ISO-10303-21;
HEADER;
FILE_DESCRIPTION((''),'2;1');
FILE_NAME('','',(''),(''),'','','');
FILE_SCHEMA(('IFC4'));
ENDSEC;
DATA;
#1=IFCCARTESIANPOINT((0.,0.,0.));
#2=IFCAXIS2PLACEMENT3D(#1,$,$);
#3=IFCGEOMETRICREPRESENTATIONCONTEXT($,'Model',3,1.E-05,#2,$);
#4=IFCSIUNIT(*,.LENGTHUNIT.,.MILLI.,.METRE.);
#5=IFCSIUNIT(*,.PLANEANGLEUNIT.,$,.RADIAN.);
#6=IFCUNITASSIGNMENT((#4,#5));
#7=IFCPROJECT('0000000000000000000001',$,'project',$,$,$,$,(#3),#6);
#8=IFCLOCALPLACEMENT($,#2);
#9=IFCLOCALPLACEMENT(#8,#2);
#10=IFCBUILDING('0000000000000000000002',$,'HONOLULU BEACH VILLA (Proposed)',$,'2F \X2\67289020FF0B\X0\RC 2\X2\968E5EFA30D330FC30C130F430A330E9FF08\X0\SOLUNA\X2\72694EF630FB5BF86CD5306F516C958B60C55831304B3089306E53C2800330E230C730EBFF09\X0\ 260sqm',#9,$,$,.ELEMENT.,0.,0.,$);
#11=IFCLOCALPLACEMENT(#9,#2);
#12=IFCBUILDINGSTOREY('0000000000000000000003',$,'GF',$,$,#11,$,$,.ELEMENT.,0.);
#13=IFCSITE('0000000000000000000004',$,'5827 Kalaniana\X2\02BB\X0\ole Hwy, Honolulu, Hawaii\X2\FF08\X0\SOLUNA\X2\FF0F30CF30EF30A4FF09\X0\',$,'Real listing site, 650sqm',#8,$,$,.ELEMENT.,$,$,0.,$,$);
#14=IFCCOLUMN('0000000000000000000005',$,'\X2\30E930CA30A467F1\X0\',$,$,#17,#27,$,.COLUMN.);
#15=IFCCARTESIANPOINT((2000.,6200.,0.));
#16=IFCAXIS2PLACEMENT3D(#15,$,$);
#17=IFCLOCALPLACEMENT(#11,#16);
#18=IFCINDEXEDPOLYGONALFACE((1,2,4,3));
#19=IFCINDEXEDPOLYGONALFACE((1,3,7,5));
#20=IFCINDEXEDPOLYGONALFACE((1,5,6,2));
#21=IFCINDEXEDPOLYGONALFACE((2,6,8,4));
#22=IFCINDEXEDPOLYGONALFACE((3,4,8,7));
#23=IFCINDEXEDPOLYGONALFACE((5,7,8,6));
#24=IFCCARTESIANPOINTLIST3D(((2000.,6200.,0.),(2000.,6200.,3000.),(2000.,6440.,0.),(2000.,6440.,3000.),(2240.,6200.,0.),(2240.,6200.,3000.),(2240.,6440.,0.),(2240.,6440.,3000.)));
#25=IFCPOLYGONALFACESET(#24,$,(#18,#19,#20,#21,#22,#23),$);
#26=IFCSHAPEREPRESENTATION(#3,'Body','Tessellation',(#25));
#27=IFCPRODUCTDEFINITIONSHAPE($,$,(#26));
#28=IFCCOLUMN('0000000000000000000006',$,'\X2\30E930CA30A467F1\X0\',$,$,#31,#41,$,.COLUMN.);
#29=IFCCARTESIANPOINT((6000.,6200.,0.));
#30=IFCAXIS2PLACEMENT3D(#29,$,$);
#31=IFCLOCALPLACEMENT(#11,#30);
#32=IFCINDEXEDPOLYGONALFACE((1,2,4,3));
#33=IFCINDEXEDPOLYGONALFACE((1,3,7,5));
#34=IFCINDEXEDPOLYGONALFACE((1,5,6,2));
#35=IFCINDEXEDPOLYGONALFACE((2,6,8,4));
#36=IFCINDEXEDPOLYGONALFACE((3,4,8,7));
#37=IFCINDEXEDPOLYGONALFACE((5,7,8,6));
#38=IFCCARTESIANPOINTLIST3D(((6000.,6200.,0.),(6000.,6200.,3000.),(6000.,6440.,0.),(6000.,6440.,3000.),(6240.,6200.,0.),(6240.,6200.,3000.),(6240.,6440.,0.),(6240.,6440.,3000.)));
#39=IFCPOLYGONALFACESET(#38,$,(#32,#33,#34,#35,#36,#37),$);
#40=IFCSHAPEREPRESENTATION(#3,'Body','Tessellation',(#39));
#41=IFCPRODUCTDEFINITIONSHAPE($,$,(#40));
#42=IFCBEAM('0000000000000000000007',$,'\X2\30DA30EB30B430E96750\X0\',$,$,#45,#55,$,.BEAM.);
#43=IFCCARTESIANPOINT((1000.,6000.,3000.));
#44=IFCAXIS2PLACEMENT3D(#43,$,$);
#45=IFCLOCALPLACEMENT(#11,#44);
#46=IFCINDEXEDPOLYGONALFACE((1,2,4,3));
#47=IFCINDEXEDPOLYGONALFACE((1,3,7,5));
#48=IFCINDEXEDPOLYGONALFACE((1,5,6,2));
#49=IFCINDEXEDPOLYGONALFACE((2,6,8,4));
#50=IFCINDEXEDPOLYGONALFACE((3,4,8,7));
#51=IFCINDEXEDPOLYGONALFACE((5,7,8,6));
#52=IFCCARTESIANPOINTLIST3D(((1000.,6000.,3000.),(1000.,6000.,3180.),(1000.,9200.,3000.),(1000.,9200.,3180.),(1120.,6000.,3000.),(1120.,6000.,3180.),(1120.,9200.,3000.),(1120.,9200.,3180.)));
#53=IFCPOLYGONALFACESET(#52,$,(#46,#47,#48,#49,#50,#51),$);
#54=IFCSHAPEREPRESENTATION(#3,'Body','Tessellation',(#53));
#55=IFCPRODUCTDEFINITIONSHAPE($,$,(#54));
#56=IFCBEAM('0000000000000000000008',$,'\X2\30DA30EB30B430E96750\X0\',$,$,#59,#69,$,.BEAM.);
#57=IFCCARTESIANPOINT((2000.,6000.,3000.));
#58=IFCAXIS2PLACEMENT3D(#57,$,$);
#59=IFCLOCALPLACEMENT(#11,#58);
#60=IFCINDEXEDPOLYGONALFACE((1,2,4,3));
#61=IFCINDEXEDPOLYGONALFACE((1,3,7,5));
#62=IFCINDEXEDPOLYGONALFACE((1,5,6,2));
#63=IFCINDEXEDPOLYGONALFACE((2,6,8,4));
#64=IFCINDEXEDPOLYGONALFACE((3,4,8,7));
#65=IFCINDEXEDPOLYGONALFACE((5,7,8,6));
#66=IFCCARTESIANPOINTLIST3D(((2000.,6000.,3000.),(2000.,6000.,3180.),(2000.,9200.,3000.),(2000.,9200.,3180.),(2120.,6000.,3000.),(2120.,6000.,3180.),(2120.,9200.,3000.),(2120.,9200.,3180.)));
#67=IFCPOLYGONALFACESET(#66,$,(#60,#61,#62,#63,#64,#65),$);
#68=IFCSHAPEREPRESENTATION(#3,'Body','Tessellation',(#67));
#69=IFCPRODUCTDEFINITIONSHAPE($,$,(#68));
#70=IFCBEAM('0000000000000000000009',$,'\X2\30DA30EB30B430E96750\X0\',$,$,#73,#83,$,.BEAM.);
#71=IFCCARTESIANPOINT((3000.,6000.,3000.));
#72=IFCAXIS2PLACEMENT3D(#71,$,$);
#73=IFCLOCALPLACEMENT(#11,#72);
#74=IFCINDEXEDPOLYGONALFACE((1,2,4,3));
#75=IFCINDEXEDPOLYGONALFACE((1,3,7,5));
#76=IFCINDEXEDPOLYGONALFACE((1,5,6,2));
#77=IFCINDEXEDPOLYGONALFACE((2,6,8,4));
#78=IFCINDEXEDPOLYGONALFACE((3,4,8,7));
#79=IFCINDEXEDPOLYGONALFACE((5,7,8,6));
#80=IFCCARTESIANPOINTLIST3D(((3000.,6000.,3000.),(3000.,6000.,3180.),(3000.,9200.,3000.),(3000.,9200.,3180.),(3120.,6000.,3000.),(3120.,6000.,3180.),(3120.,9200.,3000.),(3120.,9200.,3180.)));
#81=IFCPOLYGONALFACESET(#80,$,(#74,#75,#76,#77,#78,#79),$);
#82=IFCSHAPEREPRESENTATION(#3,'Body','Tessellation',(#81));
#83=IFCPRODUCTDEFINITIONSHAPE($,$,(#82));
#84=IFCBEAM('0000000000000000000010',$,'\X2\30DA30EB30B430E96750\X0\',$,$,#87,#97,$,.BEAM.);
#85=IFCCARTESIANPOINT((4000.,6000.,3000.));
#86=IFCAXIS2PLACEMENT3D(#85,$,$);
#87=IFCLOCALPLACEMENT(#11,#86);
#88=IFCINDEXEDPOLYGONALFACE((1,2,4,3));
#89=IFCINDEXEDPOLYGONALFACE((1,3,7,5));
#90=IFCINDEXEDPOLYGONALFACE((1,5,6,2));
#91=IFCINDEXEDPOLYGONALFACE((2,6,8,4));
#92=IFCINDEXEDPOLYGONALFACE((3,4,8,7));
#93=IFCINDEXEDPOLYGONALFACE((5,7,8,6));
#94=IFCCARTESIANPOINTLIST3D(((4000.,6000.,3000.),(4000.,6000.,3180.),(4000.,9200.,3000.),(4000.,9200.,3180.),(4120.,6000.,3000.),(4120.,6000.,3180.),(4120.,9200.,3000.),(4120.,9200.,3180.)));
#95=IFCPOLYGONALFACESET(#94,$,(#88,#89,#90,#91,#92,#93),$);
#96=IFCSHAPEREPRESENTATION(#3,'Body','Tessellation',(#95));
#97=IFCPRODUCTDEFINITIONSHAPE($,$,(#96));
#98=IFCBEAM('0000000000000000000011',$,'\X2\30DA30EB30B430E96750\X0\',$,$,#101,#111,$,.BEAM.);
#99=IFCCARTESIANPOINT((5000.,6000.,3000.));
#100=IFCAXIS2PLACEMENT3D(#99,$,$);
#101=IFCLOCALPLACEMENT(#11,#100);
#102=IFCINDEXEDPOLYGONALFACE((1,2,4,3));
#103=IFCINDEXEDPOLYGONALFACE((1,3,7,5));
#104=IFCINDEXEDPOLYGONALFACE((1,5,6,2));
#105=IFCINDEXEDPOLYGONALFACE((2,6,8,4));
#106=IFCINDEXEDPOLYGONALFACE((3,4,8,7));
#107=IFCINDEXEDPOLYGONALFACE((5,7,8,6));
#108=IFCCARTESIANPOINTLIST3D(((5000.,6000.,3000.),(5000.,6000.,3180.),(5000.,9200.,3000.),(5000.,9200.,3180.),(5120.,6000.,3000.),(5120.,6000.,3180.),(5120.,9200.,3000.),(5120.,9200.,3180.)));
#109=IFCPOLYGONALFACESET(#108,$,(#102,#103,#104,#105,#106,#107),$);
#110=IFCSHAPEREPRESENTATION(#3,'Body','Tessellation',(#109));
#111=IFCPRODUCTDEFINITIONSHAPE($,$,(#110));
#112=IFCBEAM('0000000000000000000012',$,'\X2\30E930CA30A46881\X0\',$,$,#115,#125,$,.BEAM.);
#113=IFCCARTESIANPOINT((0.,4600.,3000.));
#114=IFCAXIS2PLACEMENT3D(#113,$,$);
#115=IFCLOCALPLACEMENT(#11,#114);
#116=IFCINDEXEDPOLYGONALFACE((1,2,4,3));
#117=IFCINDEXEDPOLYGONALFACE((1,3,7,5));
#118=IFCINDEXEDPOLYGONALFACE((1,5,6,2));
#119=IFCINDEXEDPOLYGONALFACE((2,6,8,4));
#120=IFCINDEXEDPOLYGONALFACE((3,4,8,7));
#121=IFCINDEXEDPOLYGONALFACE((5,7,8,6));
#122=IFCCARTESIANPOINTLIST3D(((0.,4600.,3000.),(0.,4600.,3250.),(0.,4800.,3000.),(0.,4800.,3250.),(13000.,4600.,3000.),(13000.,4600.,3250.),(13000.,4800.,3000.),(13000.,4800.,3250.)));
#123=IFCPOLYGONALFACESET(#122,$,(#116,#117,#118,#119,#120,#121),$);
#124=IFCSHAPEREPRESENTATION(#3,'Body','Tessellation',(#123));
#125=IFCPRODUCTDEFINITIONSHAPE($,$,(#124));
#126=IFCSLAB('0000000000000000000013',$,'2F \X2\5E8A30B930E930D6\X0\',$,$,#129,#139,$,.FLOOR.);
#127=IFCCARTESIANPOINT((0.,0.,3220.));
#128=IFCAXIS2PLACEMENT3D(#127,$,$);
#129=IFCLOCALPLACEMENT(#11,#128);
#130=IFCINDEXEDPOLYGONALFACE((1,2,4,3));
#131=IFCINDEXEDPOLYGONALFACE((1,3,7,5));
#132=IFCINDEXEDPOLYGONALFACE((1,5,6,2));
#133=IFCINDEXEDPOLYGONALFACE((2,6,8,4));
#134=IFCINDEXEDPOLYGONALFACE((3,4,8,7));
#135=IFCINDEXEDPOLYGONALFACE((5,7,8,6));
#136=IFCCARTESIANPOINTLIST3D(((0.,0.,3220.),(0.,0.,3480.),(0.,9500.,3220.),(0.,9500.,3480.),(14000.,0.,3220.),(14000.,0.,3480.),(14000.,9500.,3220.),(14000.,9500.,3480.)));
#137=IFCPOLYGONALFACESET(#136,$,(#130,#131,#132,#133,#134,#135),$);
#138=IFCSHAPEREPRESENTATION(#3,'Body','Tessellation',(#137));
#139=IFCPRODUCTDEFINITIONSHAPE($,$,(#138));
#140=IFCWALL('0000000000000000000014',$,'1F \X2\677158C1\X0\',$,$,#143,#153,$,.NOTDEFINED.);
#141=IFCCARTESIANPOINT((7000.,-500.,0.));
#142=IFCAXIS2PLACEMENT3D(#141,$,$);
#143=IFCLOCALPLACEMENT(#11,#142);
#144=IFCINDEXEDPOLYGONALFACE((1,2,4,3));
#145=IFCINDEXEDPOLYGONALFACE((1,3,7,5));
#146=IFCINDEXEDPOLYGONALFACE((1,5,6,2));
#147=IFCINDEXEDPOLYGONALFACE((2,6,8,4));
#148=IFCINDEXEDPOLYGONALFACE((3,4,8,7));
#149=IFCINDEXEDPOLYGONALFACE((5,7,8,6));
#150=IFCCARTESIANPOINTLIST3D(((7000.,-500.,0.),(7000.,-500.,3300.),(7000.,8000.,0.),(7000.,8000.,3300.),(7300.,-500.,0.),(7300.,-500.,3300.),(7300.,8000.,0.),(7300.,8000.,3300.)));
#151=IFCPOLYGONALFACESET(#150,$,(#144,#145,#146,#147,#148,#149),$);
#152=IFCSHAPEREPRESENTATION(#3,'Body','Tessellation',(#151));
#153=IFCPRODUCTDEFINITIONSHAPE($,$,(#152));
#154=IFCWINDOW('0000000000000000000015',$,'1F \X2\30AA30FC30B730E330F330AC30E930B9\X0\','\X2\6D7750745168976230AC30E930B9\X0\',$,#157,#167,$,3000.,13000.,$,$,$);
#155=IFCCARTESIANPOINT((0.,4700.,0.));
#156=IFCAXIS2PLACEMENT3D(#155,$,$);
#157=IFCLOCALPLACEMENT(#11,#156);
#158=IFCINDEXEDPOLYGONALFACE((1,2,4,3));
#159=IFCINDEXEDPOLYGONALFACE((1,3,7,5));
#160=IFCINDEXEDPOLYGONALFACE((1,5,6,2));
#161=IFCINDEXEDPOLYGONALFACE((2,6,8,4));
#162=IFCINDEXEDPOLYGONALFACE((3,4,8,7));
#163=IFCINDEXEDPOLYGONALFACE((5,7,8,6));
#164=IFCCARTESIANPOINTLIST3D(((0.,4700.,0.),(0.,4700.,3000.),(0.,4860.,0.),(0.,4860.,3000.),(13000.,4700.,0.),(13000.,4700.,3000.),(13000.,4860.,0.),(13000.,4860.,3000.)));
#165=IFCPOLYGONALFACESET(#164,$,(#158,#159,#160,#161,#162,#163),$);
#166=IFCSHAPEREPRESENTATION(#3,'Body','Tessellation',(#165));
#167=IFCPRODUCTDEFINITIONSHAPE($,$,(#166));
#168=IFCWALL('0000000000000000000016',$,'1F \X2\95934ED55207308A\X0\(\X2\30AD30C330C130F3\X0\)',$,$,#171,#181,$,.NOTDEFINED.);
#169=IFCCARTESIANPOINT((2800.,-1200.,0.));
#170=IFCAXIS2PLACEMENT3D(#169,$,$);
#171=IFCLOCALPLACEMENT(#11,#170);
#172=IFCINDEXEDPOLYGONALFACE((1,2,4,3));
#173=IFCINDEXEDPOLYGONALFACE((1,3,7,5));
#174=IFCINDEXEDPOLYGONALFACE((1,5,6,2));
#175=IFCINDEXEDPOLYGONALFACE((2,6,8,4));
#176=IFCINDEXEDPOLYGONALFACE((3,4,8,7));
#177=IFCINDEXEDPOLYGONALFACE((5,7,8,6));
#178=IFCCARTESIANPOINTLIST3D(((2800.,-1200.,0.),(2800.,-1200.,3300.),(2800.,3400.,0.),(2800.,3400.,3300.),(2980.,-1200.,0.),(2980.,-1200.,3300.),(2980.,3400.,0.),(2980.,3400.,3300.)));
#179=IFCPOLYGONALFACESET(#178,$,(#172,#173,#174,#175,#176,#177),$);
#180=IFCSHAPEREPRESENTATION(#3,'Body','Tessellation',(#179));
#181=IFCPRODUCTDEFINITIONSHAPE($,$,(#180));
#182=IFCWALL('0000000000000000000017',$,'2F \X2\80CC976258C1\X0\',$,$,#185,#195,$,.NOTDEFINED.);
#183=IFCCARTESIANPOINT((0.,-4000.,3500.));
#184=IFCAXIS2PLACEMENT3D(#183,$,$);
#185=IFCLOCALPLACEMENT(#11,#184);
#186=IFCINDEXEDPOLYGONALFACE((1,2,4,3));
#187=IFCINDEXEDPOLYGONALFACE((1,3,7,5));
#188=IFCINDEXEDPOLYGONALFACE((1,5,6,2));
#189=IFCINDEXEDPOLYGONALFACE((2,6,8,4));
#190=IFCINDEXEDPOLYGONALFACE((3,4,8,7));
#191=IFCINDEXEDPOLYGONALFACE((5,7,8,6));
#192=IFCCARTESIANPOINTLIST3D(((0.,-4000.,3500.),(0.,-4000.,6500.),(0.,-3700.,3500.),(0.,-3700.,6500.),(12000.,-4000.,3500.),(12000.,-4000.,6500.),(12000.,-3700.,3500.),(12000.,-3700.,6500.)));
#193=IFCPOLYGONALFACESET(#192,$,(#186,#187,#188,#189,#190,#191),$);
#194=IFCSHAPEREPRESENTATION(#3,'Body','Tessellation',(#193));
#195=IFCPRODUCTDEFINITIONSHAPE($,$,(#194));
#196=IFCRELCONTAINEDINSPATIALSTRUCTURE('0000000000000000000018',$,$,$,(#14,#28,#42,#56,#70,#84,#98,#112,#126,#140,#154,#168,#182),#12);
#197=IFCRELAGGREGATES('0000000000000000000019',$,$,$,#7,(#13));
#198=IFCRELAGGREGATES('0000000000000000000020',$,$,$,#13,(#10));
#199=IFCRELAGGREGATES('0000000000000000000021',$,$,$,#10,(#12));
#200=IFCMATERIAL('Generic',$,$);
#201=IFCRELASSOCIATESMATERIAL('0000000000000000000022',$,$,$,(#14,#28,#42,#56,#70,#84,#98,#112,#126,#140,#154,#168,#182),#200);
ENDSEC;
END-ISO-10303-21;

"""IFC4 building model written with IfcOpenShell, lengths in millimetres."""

from ifc_helpers import new_model, si_unit, frame, frame_2d, origin, place, context, project, spatial, rectangle, extrude, material, element, fill, save


model = new_model("IFC4")

# Units and contexts
model_context = context("Model", 3, precision=1e-05, world=origin())
ifc_project = project(units=[si_unit("LENGTHUNIT", "METRE", prefix="MILLI"), si_unit("PLANEANGLEUNIT", "RADIAN")], contexts=[model_context])

# Site, building, storey
site_placement = place(None, origin())
site = spatial("IfcSite", under=ifc_project, at=site_placement, Name="5827 Kalanianaʻole Hwy, Honolulu, Hawaii（SOLUNA／ハワイ）", ObjectType="Real listing site, 650sqm", CompositionType="ELEMENT", RefElevation=0.0)
building_placement = place(site_placement, origin())
building = spatial("IfcBuilding", under=site, at=building_placement, Name="HONOLULU BEACH VILLA (Proposed)", ObjectType="2F 木造＋RC 2階建ビーチヴィラ（SOLUNA物件・寸法は公開情報からの参考モデル） 260sqm", CompositionType="ELEMENT", ElevationOfRefHeight=0.0, ElevationOfTerrain=0.0)
storey_placement = place(building_placement, origin())
storey = spatial("IfcBuildingStorey", under=building, at=storey_placement, Name="GF", CompositionType="ELEMENT", Elevation=0.0)

# Columns
ifc_material_1 = material(Name="Generic")
column_1_placement = place(storey_placement, frame((2000.0, 6200.0, 0.0)))
element("IfcColumn", 1, at=column_1_placement, inside=storey, material=ifc_material_1, Name="ラナイ柱", PredefinedType="COLUMN", context=model_context, shape_type="SweptSolid", body=[
    extrude(rectangle(XDim=240.0, YDim=240.0, at=frame_2d((120.0, 120.0))), frame((2000.0, 6200.0, 0.0)), (0.0, 0.0, 1.0), 3000.0),
])
column_2_placement = place(storey_placement, frame((6000.0, 6200.0, 0.0)))
element("IfcColumn", 2, at=column_2_placement, inside=storey, material=ifc_material_1, Name="ラナイ柱", PredefinedType="COLUMN", context=model_context, shape_type="SweptSolid", body=[
    extrude(rectangle(XDim=240.0, YDim=240.0, at=frame_2d((120.0, 120.0))), frame((6000.0, 6200.0, 0.0)), (0.0, 0.0, 1.0), 3000.0),
])

# Beams
beam_1_placement = place(storey_placement, frame((1000.0, 6000.0, 3000.0)))
element("IfcBeam", 3, at=beam_1_placement, inside=storey, material=ifc_material_1, Name="ペルゴラ材", PredefinedType="BEAM", context=model_context, shape_type="SweptSolid", body=[
    extrude(rectangle(XDim=120.0, YDim=3200.0, at=frame_2d((60.0, 1600.0))), frame((1000.0, 6000.0, 3000.0)), (0.0, 0.0, 1.0), 180.0),
])
beam_2_placement = place(storey_placement, frame((2000.0, 6000.0, 3000.0)))
element("IfcBeam", 4, at=beam_2_placement, inside=storey, material=ifc_material_1, Name="ペルゴラ材", PredefinedType="BEAM", context=model_context, shape_type="SweptSolid", body=[
    extrude(rectangle(XDim=120.0, YDim=3200.0, at=frame_2d((60.0, 1600.0))), frame((2000.0, 6000.0, 3000.0)), (0.0, 0.0, 1.0), 180.0),
])
beam_3_placement = place(storey_placement, frame((3000.0, 6000.0, 3000.0)))
element("IfcBeam", 5, at=beam_3_placement, inside=storey, material=ifc_material_1, Name="ペルゴラ材", PredefinedType="BEAM", context=model_context, shape_type="SweptSolid", body=[
    extrude(rectangle(XDim=120.0, YDim=3200.0, at=frame_2d((60.0, 1600.0))), frame((3000.0, 6000.0, 3000.0)), (0.0, 0.0, 1.0), 180.0),
])
beam_4_placement = place(storey_placement, frame((4000.0, 6000.0, 3000.0)))
element("IfcBeam", 6, at=beam_4_placement, inside=storey, material=ifc_material_1, Name="ペルゴラ材", PredefinedType="BEAM", context=model_context, shape_type="SweptSolid", body=[
    extrude(rectangle(XDim=120.0, YDim=3200.0, at=frame_2d((60.0, 1600.0))), frame((4000.0, 6000.0, 3000.0)), (0.0, 0.0, 1.0), 180.0),
])
beam_5_placement = place(storey_placement, frame((5000.0, 6000.0, 3000.0)))
element("IfcBeam", 7, at=beam_5_placement, inside=storey, material=ifc_material_1, Name="ペルゴラ材", PredefinedType="BEAM", context=model_context, shape_type="SweptSolid", body=[
    extrude(rectangle(XDim=120.0, YDim=3200.0, at=frame_2d((60.0, 1600.0))), frame((5000.0, 6000.0, 3000.0)), (0.0, 0.0, 1.0), 180.0),
])
beam_6_placement = place(storey_placement, frame((0.0, 4600.0, 3000.0)))
element("IfcBeam", 8, at=beam_6_placement, inside=storey, material=ifc_material_1, Name="ラナイ梁", PredefinedType="BEAM", context=model_context, shape_type="SweptSolid", body=[
    extrude(rectangle(XDim=13000.0, YDim=200.0, at=frame_2d((6500.0, 100.0))), frame((0.0, 4600.0, 3000.0)), (0.0, 0.0, 1.0), 250.0),
])

# Slab
slab_placement = place(storey_placement, frame((0.0, 0.0, 3220.0)))
element("IfcSlab", 9, at=slab_placement, inside=storey, material=ifc_material_1, Name="2F 床スラブ", PredefinedType="FLOOR", context=model_context, shape_type="SweptSolid", body=[
    extrude(rectangle(XDim=14000.0, YDim=9500.0, at=frame_2d((7000.0, 4750.0))), frame((0.0, 0.0, 3220.0)), (0.0, 0.0, 1.0), 260.0),
])

# Wall, opening, window
wall_1_placement = place(storey_placement, frame((7000.0, -500.0, 0.0)))
wall_1 = element("IfcWall", 10, at=wall_1_placement, inside=storey, material=ifc_material_1, Name="1F 東壁", PredefinedType="NOTDEFINED", context=model_context, shape_type="SweptSolid", body=[
    extrude(rectangle(XDim=300.0, YDim=8500.0, at=frame_2d((150.0, 4250.0))), frame((7000.0, -500.0, 0.0)), (0.0, 0.0, 1.0), 3300.0),
])
opening_1_placement = place(storey_placement, frame((0.0, 4700.0, 0.0)))
opening_1 = element("IfcOpeningElement", 11, at=opening_1_placement, cuts=wall_1, PredefinedType="NOTDEFINED", context=model_context, shape_type="SweptSolid", body=[
    extrude(rectangle(XDim=13000.0, YDim=160.0, at=frame_2d((6500.0, 80.0))), frame((0.0, 4700.0, 0.0)), (0.0, 0.0, 1.0), 3000.0),
])
window_1_placement = place(storey_placement, frame((0.0, 4700.0, 0.0)))
window_1 = element("IfcWindow", 12, at=window_1_placement, inside=storey, material=ifc_material_1, Name="1F オーシャンガラス", Description="海側全面ガラス", OverallHeight=3000.0, OverallWidth=13000.0, context=model_context, shape_type="SweptSolid", body=[
    extrude(rectangle(XDim=13000.0, YDim=160.0, at=frame_2d((6500.0, 80.0))), frame((0.0, 4700.0, 0.0)), (0.0, 0.0, 1.0), 3000.0),
])
fill(opening_1, window_1)

# Walls
wall_2_placement = place(storey_placement, frame((2800.0, -1200.0, 0.0)))
element("IfcWall", 13, at=wall_2_placement, inside=storey, material=ifc_material_1, Name="1F 間仕切り(キッチン)", PredefinedType="NOTDEFINED", context=model_context, shape_type="SweptSolid", body=[
    extrude(rectangle(XDim=180.0, YDim=4600.0, at=frame_2d((90.0, 2300.0))), frame((2800.0, -1200.0, 0.0)), (0.0, 0.0, 1.0), 3300.0),
])
wall_3_placement = place(storey_placement, frame((0.0, -4000.0, 3500.0)))
element("IfcWall", 14, at=wall_3_placement, inside=storey, material=ifc_material_1, Name="2F 背面壁", PredefinedType="NOTDEFINED", context=model_context, shape_type="SweptSolid", body=[
    extrude(rectangle(XDim=12000.0, YDim=300.0, at=frame_2d((6000.0, 150.0))), frame((0.0, -4000.0, 3500.0)), (0.0, 0.0, 1.0), 3000.0),
])

save(model, "model.ifc")
